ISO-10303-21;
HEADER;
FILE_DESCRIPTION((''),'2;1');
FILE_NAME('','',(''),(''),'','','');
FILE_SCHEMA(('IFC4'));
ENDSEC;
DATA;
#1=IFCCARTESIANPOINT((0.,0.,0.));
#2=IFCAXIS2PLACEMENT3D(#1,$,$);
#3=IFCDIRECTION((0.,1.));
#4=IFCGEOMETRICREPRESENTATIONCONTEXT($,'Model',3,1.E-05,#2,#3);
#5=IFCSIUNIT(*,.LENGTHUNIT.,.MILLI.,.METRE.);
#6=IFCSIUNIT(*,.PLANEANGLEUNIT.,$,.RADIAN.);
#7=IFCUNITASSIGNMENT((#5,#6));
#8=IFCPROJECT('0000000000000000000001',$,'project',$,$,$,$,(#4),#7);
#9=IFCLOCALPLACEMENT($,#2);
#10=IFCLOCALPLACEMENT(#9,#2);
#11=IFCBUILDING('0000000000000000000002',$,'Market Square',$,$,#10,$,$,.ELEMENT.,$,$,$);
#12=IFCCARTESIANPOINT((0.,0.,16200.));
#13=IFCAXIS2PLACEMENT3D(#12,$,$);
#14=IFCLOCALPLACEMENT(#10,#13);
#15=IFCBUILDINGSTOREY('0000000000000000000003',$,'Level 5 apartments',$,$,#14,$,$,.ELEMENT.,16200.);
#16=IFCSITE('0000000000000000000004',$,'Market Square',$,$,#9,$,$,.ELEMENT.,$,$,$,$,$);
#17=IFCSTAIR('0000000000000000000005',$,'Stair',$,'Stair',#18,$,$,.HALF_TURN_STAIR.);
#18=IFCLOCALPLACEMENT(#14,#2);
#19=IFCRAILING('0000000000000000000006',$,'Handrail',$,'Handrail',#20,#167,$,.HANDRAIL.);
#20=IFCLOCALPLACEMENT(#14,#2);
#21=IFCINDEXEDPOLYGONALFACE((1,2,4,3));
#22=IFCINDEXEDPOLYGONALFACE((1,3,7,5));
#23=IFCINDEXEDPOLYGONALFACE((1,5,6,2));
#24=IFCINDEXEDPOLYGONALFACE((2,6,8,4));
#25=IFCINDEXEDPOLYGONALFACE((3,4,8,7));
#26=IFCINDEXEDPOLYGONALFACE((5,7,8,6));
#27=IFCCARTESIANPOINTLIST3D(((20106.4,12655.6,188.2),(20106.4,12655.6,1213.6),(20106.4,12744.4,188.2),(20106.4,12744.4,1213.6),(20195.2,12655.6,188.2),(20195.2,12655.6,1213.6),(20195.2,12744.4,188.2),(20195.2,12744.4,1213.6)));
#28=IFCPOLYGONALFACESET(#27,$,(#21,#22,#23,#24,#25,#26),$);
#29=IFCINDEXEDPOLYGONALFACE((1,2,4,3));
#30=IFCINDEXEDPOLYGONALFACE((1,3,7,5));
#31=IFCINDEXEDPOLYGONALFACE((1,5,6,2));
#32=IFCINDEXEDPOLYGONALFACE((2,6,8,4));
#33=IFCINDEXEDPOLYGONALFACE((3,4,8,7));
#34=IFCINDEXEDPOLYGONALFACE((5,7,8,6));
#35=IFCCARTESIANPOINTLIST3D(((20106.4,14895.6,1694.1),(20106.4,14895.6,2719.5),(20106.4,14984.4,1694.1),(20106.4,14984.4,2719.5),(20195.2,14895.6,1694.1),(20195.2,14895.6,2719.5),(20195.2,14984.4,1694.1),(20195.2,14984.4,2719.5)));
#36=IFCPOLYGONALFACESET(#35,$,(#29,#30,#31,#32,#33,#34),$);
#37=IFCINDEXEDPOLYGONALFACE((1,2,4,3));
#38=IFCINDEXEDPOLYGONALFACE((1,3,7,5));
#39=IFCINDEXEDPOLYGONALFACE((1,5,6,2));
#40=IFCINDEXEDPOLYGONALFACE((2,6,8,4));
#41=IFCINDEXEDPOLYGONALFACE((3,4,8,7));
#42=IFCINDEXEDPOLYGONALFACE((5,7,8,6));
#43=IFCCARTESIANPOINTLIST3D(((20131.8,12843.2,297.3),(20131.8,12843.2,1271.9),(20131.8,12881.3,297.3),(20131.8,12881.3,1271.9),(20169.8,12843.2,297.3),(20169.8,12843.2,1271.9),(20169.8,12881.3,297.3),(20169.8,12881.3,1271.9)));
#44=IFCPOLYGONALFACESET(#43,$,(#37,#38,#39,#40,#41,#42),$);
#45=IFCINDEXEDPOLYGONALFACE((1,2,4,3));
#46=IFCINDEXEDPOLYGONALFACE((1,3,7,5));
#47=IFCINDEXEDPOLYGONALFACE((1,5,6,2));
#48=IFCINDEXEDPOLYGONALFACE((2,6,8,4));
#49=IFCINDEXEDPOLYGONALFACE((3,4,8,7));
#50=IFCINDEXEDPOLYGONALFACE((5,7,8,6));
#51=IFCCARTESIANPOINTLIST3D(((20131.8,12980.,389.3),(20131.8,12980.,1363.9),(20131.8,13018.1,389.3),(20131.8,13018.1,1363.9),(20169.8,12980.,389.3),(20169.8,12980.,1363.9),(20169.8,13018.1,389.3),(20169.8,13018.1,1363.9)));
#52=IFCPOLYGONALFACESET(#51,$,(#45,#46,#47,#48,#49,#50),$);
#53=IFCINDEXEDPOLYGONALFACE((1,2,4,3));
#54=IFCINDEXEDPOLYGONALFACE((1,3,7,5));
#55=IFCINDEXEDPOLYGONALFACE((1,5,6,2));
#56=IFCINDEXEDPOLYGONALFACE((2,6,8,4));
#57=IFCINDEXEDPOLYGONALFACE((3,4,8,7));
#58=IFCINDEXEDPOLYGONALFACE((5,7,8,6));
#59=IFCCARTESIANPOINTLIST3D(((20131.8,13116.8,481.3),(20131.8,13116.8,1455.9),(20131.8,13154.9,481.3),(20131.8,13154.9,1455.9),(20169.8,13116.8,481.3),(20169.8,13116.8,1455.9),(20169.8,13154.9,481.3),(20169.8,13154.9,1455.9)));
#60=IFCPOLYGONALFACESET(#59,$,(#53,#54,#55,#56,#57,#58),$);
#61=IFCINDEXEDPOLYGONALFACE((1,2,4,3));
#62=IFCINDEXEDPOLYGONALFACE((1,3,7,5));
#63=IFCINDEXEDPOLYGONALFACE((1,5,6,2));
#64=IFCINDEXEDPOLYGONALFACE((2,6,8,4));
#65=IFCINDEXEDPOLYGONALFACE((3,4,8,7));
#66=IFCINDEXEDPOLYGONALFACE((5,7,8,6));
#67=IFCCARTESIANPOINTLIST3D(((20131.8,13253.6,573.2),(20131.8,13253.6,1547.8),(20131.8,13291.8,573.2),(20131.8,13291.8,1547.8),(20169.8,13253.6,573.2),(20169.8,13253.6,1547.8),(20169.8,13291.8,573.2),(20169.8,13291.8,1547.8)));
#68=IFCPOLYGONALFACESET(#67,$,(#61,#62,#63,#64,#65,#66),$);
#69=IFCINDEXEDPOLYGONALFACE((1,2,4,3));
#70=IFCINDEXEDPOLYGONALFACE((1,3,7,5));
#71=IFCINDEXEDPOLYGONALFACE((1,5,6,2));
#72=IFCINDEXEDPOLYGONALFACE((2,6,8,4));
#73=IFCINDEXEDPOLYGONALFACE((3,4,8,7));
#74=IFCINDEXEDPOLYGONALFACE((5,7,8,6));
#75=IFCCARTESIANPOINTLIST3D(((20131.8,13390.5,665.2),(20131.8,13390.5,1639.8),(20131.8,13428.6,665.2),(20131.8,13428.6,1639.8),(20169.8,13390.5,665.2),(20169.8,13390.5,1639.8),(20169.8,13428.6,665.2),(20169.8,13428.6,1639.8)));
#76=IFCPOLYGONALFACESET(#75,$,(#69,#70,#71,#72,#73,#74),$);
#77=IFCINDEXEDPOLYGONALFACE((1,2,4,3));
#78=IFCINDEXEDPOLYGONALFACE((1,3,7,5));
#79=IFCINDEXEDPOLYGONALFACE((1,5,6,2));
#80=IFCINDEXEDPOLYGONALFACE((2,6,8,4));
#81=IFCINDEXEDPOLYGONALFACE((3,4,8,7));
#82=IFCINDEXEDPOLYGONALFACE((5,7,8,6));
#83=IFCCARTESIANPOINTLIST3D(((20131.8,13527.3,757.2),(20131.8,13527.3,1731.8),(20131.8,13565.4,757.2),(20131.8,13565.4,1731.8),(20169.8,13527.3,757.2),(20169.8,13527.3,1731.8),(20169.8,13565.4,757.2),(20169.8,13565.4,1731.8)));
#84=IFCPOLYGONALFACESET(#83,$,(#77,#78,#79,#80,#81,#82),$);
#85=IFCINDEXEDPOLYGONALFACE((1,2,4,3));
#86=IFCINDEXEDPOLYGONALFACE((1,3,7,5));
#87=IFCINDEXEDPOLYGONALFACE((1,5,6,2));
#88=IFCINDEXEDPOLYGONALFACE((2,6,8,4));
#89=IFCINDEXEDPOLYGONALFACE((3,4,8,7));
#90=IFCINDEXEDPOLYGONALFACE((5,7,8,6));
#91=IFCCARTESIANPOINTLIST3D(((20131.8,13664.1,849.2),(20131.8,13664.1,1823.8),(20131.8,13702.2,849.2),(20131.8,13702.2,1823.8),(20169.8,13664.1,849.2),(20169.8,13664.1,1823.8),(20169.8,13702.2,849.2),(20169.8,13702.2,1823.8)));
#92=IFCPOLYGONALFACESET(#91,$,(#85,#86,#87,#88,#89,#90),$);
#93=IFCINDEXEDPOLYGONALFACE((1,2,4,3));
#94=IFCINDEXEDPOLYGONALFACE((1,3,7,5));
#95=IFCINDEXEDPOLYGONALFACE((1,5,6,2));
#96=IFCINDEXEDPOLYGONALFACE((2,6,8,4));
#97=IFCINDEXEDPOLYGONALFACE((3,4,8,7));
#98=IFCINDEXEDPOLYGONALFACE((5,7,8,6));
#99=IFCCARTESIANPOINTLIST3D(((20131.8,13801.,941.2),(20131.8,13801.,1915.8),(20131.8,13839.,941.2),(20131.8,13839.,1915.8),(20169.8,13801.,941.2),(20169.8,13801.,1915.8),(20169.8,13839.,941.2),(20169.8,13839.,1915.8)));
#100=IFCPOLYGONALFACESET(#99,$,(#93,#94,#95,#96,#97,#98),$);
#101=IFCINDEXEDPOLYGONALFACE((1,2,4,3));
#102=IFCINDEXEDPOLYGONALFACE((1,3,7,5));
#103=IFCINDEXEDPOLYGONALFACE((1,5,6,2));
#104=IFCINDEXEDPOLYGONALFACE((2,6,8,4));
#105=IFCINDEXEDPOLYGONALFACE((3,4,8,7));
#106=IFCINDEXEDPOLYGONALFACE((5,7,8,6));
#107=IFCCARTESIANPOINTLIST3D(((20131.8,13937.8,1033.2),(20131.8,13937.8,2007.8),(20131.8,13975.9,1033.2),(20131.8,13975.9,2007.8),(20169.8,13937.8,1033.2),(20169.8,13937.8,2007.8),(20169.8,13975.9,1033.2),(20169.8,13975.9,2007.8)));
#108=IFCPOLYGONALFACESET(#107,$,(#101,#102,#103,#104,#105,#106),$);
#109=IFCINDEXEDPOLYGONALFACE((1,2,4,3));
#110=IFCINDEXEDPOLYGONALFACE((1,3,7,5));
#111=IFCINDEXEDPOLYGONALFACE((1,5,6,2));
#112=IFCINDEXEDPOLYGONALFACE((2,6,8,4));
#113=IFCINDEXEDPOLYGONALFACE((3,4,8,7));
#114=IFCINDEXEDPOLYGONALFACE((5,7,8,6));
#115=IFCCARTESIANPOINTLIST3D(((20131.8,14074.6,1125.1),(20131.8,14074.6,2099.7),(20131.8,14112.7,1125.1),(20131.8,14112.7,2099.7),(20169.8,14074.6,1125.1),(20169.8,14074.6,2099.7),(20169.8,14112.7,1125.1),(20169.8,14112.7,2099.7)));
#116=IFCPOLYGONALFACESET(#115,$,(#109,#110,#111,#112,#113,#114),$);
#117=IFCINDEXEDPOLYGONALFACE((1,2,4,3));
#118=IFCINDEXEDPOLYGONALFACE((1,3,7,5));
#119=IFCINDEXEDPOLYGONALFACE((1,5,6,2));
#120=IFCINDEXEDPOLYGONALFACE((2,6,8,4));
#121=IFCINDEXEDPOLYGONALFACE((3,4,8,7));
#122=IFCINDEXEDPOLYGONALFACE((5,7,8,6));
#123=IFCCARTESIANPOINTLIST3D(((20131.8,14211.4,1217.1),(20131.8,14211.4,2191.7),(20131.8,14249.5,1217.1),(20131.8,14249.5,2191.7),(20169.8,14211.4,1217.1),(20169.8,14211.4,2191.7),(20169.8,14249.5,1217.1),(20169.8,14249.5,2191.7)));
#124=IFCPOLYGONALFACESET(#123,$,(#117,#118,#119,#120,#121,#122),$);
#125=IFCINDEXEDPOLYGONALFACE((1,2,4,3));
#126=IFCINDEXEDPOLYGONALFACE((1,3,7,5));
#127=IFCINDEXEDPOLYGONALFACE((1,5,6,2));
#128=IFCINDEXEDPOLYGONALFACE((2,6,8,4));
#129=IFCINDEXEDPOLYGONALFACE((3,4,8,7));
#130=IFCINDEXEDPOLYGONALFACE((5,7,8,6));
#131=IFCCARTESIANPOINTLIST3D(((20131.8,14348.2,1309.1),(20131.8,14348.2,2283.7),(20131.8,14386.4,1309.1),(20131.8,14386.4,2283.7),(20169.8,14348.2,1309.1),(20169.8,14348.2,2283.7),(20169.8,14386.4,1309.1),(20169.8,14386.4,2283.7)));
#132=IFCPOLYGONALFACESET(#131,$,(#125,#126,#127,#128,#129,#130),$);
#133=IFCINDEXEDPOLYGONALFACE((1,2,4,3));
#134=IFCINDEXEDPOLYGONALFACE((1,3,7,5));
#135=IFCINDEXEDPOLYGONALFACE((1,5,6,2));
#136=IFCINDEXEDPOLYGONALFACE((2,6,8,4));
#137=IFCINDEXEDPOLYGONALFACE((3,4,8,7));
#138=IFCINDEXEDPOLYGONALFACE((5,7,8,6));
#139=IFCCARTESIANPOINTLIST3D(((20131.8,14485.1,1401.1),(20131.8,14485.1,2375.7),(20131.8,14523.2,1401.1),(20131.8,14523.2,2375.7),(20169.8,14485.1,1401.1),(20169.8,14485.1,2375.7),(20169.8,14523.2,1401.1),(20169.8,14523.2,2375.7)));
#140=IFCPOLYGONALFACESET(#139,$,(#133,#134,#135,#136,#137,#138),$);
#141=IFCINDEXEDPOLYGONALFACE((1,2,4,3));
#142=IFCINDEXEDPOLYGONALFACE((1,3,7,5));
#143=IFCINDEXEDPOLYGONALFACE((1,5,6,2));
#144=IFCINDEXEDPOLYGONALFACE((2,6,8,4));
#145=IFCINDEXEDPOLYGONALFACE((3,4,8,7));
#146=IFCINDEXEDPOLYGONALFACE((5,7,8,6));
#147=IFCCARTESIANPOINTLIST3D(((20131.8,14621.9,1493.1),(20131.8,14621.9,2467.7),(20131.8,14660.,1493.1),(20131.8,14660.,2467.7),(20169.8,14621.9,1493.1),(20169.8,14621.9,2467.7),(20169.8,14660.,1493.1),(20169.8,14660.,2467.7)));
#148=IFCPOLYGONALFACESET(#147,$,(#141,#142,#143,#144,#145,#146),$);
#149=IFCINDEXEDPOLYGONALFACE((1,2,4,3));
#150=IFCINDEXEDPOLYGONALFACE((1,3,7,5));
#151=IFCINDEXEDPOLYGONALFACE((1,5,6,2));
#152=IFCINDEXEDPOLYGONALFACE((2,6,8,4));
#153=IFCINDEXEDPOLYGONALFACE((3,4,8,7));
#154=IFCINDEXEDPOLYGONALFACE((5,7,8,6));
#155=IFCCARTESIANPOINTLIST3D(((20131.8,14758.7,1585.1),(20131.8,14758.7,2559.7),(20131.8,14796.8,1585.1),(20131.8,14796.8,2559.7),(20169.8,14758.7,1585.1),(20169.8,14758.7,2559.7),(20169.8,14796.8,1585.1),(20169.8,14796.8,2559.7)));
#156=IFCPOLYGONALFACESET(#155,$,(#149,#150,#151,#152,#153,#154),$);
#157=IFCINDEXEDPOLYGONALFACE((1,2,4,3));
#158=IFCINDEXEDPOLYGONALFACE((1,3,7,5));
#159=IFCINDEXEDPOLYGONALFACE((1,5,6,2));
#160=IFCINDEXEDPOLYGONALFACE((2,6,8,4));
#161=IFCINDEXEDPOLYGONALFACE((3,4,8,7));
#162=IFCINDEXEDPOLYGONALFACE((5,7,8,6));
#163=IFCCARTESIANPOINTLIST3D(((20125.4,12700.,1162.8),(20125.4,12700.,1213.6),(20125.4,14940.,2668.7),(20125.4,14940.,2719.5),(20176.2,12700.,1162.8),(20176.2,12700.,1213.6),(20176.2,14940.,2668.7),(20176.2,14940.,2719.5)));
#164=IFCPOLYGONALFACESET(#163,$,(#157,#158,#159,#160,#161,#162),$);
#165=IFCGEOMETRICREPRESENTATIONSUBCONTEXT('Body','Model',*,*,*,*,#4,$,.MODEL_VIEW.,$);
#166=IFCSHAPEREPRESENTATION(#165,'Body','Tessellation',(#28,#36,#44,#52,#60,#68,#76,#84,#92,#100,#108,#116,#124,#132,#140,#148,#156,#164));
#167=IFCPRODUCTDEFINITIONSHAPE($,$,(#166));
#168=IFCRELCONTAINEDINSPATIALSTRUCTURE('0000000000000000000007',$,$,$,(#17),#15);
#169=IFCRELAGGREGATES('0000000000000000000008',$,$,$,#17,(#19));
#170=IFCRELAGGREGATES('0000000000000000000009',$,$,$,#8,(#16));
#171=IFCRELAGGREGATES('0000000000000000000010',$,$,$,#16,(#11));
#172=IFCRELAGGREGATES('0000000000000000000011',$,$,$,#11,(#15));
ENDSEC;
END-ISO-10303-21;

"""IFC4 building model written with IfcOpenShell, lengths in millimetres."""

from ifc_helpers import new_model, si_unit, direction, frame, origin, origin_with_axes, place, context, subcontext, project, spatial, polyline, outline, extrude, element, aggregate, save


model = new_model("IFC4")

# Units and contexts
model_context = context("Model", 3, precision=1e-05, world=origin(), true_north=direction((0.0, 1.0)))
body_context = subcontext(model_context, "Body", "Model", "MODEL_VIEW")
ifc_project = project(units=[si_unit("LENGTHUNIT", "METRE", prefix="MILLI"), si_unit("PLANEANGLEUNIT", "RADIAN")], contexts=[model_context])

# Site, building, storey
site_placement = place(None, origin())
site = spatial("IfcSite", under=ifc_project, at=site_placement, Name="Market Square", CompositionType="ELEMENT")
building_placement = place(site_placement, origin())
building = spatial("IfcBuilding", under=site, at=building_placement, Name="Market Square", CompositionType="ELEMENT")
storey_placement = place(building_placement, frame((0.0, 0.0, 16200.0)))
storey = spatial("IfcBuildingStorey", under=building, at=storey_placement, Name="Level 5 apartments", CompositionType="ELEMENT", Elevation=16200.0)

# Stair
stair_placement = place(storey_placement, origin_with_axes())
stair = element("IfcStair", 1, at=stair_placement, inside=storey, Name="Stair", ObjectType="Stair", PredefinedType="HALF_TURN_STAIR")

# Railing
railing_1_placement = place(storey_placement, origin_with_axes())
railing_1 = element("IfcRailing", 2, at=railing_1_placement, Name="Handrail", ObjectType="Handrail", PredefinedType="HANDRAIL", context=body_context, shape_type="SweptSolid", body=[
    extrude(outline(polyline([(-44.5, -44.5), (44.5, -44.5), (44.5, 44.5), (-44.5, 44.5), (-44.5, -44.5)])), frame((20150.8, 12700.0, 188.2), z_axis=(0.0, 0.0, 1.0), x_axis=(1.0, 0.0, 0.0)), (0.0, 0.0, 1.0), 1025.4),
    extrude(outline(polyline([(-44.5, -44.5), (44.5, -44.5), (44.5, 44.5), (-44.5, 44.5), (-44.5, -44.5)])), frame((20150.8, 14940.0, 1694.1), z_axis=(0.0, 0.0, 1.0), x_axis=(1.0, 0.0, 0.0)), (0.0, 0.0, 1.0), 1025.4),
    extrude(outline(polyline([(-19.1, -19.1), (19.1, -19.1), (19.1, 19.1), (-19.1, 19.1), (-19.1, -19.1)])), frame((20150.8, 12862.2, 297.3), z_axis=(0.0, 0.0, 1.0), x_axis=(1.0, 0.0, 0.0)), (0.0, 0.0, 1.0), 974.6),
    extrude(outline(polyline([(-19.1, -19.1), (19.1, -19.1), (19.1, 19.1), (-19.1, 19.1), (-19.1, -19.1)])), frame((20150.8, 12999.0, 389.3), z_axis=(0.0, 0.0, 1.0), x_axis=(1.0, 0.0, 0.0)), (0.0, 0.0, 1.0), 974.6),
    extrude(outline(polyline([(-19.1, -19.1), (19.1, -19.1), (19.1, 19.1), (-19.1, 19.1), (-19.1, -19.1)])), frame((20150.8, 13135.9, 481.3), z_axis=(0.0, 0.0, 1.0), x_axis=(1.0, 0.0, 0.0)), (0.0, 0.0, 1.0), 974.6),
    extrude(outline(polyline([(-19.1, -19.1), (19.1, -19.1), (19.1, 19.1), (-19.1, 19.1), (-19.1, -19.1)])), frame((20150.8, 13272.7, 573.2), z_axis=(0.0, 0.0, 1.0), x_axis=(1.0, 0.0, 0.0)), (0.0, 0.0, 1.0), 974.6),
    extrude(outline(polyline([(-19.1, -19.1), (19.1, -19.1), (19.1, 19.1), (-19.1, 19.1), (-19.1, -19.1)])), frame((20150.8, 13409.5, 665.2), z_axis=(0.0, 0.0, 1.0), x_axis=(1.0, 0.0, 0.0)), (0.0, 0.0, 1.0), 974.6),
    extrude(outline(polyline([(-19.1, -19.1), (19.1, -19.1), (19.1, 19.1), (-19.1, 19.1), (-19.1, -19.1)])), frame((20150.8, 13546.4, 757.2), z_axis=(0.0, 0.0, 1.0), x_axis=(1.0, 0.0, 0.0)), (0.0, 0.0, 1.0), 974.6),
    extrude(outline(polyline([(-19.1, -19.1), (19.1, -19.1), (19.1, 19.1), (-19.1, 19.1), (-19.1, -19.1)])), frame((20150.8, 13683.2, 849.2), z_axis=(0.0, 0.0, 1.0), x_axis=(1.0, 0.0, 0.0)), (0.0, 0.0, 1.0), 974.6),
    extrude(outline(polyline([(-19.1, -19.1), (19.1, -19.1), (19.1, 19.1), (-19.1, 19.1), (-19.1, -19.1)])), frame((20150.8, 13820.0, 941.2), z_axis=(0.0, 0.0, 1.0), x_axis=(1.0, 0.0, 0.0)), (0.0, 0.0, 1.0), 974.6),
    extrude(outline(polyline([(-19.1, -19.1), (19.1, -19.1), (19.1, 19.1), (-19.1, 19.1), (-19.1, -19.1)])), frame((20150.8, 13956.8, 1033.2), z_axis=(0.0, 0.0, 1.0), x_axis=(1.0, 0.0, 0.0)), (0.0, 0.0, 1.0), 974.6),
    extrude(outline(polyline([(-19.1, -19.1), (19.1, -19.1), (19.1, 19.1), (-19.1, 19.1), (-19.1, -19.1)])), frame((20150.8, 14093.6, 1125.1), z_axis=(0.0, 0.0, 1.0), x_axis=(1.0, 0.0, 0.0)), (0.0, 0.0, 1.0), 974.6),
    extrude(outline(polyline([(-19.1, -19.1), (19.1, -19.1), (19.1, 19.1), (-19.1, 19.1), (-19.1, -19.1)])), frame((20150.8, 14230.5, 1217.1), z_axis=(0.0, 0.0, 1.0), x_axis=(1.0, 0.0, 0.0)), (0.0, 0.0, 1.0), 974.6),
    extrude(outline(polyline([(-19.1, -19.1), (19.1, -19.1), (19.1, 19.1), (-19.1, 19.1), (-19.1, -19.1)])), frame((20150.8, 14367.3, 1309.1), z_axis=(0.0, 0.0, 1.0), x_axis=(1.0, 0.0, 0.0)), (0.0, 0.0, 1.0), 974.6),
    extrude(outline(polyline([(-19.1, -19.1), (19.1, -19.1), (19.1, 19.1), (-19.1, 19.1), (-19.1, -19.1)])), frame((20150.8, 14504.1, 1401.1), z_axis=(0.0, 0.0, 1.0), x_axis=(1.0, 0.0, 0.0)), (0.0, 0.0, 1.0), 974.6),
    extrude(outline(polyline([(-19.1, -19.1), (19.1, -19.1), (19.1, 19.1), (-19.1, 19.1), (-19.1, -19.1)])), frame((20150.8, 14641.0, 1493.1), z_axis=(0.0, 0.0, 1.0), x_axis=(1.0, 0.0, 0.0)), (0.0, 0.0, 1.0), 974.6),
    extrude(outline(polyline([(-19.1, -19.1), (19.1, -19.1), (19.1, 19.1), (-19.1, 19.1), (-19.1, -19.1)])), frame((20150.8, 14777.8, 1585.1), z_axis=(0.0, 0.0, 1.0), x_axis=(1.0, 0.0, 0.0)), (0.0, 0.0, 1.0), 974.6),
    extrude(outline(polyline([(0.0, 0.0), (50.8, 0.0), (50.8, 50.8), (0.0, 50.8), (0.0, 0.0)])), frame((20176.2, 12700.0, 1162.8), z_axis=(0.0, 1.0, 0.0), x_axis=(-1.0, 0.0, 0.0)), (0.0, 0.557915, 0.829898), 2699.1),
])
aggregate(stair, [railing_1])

save(model, "model.ifc")
